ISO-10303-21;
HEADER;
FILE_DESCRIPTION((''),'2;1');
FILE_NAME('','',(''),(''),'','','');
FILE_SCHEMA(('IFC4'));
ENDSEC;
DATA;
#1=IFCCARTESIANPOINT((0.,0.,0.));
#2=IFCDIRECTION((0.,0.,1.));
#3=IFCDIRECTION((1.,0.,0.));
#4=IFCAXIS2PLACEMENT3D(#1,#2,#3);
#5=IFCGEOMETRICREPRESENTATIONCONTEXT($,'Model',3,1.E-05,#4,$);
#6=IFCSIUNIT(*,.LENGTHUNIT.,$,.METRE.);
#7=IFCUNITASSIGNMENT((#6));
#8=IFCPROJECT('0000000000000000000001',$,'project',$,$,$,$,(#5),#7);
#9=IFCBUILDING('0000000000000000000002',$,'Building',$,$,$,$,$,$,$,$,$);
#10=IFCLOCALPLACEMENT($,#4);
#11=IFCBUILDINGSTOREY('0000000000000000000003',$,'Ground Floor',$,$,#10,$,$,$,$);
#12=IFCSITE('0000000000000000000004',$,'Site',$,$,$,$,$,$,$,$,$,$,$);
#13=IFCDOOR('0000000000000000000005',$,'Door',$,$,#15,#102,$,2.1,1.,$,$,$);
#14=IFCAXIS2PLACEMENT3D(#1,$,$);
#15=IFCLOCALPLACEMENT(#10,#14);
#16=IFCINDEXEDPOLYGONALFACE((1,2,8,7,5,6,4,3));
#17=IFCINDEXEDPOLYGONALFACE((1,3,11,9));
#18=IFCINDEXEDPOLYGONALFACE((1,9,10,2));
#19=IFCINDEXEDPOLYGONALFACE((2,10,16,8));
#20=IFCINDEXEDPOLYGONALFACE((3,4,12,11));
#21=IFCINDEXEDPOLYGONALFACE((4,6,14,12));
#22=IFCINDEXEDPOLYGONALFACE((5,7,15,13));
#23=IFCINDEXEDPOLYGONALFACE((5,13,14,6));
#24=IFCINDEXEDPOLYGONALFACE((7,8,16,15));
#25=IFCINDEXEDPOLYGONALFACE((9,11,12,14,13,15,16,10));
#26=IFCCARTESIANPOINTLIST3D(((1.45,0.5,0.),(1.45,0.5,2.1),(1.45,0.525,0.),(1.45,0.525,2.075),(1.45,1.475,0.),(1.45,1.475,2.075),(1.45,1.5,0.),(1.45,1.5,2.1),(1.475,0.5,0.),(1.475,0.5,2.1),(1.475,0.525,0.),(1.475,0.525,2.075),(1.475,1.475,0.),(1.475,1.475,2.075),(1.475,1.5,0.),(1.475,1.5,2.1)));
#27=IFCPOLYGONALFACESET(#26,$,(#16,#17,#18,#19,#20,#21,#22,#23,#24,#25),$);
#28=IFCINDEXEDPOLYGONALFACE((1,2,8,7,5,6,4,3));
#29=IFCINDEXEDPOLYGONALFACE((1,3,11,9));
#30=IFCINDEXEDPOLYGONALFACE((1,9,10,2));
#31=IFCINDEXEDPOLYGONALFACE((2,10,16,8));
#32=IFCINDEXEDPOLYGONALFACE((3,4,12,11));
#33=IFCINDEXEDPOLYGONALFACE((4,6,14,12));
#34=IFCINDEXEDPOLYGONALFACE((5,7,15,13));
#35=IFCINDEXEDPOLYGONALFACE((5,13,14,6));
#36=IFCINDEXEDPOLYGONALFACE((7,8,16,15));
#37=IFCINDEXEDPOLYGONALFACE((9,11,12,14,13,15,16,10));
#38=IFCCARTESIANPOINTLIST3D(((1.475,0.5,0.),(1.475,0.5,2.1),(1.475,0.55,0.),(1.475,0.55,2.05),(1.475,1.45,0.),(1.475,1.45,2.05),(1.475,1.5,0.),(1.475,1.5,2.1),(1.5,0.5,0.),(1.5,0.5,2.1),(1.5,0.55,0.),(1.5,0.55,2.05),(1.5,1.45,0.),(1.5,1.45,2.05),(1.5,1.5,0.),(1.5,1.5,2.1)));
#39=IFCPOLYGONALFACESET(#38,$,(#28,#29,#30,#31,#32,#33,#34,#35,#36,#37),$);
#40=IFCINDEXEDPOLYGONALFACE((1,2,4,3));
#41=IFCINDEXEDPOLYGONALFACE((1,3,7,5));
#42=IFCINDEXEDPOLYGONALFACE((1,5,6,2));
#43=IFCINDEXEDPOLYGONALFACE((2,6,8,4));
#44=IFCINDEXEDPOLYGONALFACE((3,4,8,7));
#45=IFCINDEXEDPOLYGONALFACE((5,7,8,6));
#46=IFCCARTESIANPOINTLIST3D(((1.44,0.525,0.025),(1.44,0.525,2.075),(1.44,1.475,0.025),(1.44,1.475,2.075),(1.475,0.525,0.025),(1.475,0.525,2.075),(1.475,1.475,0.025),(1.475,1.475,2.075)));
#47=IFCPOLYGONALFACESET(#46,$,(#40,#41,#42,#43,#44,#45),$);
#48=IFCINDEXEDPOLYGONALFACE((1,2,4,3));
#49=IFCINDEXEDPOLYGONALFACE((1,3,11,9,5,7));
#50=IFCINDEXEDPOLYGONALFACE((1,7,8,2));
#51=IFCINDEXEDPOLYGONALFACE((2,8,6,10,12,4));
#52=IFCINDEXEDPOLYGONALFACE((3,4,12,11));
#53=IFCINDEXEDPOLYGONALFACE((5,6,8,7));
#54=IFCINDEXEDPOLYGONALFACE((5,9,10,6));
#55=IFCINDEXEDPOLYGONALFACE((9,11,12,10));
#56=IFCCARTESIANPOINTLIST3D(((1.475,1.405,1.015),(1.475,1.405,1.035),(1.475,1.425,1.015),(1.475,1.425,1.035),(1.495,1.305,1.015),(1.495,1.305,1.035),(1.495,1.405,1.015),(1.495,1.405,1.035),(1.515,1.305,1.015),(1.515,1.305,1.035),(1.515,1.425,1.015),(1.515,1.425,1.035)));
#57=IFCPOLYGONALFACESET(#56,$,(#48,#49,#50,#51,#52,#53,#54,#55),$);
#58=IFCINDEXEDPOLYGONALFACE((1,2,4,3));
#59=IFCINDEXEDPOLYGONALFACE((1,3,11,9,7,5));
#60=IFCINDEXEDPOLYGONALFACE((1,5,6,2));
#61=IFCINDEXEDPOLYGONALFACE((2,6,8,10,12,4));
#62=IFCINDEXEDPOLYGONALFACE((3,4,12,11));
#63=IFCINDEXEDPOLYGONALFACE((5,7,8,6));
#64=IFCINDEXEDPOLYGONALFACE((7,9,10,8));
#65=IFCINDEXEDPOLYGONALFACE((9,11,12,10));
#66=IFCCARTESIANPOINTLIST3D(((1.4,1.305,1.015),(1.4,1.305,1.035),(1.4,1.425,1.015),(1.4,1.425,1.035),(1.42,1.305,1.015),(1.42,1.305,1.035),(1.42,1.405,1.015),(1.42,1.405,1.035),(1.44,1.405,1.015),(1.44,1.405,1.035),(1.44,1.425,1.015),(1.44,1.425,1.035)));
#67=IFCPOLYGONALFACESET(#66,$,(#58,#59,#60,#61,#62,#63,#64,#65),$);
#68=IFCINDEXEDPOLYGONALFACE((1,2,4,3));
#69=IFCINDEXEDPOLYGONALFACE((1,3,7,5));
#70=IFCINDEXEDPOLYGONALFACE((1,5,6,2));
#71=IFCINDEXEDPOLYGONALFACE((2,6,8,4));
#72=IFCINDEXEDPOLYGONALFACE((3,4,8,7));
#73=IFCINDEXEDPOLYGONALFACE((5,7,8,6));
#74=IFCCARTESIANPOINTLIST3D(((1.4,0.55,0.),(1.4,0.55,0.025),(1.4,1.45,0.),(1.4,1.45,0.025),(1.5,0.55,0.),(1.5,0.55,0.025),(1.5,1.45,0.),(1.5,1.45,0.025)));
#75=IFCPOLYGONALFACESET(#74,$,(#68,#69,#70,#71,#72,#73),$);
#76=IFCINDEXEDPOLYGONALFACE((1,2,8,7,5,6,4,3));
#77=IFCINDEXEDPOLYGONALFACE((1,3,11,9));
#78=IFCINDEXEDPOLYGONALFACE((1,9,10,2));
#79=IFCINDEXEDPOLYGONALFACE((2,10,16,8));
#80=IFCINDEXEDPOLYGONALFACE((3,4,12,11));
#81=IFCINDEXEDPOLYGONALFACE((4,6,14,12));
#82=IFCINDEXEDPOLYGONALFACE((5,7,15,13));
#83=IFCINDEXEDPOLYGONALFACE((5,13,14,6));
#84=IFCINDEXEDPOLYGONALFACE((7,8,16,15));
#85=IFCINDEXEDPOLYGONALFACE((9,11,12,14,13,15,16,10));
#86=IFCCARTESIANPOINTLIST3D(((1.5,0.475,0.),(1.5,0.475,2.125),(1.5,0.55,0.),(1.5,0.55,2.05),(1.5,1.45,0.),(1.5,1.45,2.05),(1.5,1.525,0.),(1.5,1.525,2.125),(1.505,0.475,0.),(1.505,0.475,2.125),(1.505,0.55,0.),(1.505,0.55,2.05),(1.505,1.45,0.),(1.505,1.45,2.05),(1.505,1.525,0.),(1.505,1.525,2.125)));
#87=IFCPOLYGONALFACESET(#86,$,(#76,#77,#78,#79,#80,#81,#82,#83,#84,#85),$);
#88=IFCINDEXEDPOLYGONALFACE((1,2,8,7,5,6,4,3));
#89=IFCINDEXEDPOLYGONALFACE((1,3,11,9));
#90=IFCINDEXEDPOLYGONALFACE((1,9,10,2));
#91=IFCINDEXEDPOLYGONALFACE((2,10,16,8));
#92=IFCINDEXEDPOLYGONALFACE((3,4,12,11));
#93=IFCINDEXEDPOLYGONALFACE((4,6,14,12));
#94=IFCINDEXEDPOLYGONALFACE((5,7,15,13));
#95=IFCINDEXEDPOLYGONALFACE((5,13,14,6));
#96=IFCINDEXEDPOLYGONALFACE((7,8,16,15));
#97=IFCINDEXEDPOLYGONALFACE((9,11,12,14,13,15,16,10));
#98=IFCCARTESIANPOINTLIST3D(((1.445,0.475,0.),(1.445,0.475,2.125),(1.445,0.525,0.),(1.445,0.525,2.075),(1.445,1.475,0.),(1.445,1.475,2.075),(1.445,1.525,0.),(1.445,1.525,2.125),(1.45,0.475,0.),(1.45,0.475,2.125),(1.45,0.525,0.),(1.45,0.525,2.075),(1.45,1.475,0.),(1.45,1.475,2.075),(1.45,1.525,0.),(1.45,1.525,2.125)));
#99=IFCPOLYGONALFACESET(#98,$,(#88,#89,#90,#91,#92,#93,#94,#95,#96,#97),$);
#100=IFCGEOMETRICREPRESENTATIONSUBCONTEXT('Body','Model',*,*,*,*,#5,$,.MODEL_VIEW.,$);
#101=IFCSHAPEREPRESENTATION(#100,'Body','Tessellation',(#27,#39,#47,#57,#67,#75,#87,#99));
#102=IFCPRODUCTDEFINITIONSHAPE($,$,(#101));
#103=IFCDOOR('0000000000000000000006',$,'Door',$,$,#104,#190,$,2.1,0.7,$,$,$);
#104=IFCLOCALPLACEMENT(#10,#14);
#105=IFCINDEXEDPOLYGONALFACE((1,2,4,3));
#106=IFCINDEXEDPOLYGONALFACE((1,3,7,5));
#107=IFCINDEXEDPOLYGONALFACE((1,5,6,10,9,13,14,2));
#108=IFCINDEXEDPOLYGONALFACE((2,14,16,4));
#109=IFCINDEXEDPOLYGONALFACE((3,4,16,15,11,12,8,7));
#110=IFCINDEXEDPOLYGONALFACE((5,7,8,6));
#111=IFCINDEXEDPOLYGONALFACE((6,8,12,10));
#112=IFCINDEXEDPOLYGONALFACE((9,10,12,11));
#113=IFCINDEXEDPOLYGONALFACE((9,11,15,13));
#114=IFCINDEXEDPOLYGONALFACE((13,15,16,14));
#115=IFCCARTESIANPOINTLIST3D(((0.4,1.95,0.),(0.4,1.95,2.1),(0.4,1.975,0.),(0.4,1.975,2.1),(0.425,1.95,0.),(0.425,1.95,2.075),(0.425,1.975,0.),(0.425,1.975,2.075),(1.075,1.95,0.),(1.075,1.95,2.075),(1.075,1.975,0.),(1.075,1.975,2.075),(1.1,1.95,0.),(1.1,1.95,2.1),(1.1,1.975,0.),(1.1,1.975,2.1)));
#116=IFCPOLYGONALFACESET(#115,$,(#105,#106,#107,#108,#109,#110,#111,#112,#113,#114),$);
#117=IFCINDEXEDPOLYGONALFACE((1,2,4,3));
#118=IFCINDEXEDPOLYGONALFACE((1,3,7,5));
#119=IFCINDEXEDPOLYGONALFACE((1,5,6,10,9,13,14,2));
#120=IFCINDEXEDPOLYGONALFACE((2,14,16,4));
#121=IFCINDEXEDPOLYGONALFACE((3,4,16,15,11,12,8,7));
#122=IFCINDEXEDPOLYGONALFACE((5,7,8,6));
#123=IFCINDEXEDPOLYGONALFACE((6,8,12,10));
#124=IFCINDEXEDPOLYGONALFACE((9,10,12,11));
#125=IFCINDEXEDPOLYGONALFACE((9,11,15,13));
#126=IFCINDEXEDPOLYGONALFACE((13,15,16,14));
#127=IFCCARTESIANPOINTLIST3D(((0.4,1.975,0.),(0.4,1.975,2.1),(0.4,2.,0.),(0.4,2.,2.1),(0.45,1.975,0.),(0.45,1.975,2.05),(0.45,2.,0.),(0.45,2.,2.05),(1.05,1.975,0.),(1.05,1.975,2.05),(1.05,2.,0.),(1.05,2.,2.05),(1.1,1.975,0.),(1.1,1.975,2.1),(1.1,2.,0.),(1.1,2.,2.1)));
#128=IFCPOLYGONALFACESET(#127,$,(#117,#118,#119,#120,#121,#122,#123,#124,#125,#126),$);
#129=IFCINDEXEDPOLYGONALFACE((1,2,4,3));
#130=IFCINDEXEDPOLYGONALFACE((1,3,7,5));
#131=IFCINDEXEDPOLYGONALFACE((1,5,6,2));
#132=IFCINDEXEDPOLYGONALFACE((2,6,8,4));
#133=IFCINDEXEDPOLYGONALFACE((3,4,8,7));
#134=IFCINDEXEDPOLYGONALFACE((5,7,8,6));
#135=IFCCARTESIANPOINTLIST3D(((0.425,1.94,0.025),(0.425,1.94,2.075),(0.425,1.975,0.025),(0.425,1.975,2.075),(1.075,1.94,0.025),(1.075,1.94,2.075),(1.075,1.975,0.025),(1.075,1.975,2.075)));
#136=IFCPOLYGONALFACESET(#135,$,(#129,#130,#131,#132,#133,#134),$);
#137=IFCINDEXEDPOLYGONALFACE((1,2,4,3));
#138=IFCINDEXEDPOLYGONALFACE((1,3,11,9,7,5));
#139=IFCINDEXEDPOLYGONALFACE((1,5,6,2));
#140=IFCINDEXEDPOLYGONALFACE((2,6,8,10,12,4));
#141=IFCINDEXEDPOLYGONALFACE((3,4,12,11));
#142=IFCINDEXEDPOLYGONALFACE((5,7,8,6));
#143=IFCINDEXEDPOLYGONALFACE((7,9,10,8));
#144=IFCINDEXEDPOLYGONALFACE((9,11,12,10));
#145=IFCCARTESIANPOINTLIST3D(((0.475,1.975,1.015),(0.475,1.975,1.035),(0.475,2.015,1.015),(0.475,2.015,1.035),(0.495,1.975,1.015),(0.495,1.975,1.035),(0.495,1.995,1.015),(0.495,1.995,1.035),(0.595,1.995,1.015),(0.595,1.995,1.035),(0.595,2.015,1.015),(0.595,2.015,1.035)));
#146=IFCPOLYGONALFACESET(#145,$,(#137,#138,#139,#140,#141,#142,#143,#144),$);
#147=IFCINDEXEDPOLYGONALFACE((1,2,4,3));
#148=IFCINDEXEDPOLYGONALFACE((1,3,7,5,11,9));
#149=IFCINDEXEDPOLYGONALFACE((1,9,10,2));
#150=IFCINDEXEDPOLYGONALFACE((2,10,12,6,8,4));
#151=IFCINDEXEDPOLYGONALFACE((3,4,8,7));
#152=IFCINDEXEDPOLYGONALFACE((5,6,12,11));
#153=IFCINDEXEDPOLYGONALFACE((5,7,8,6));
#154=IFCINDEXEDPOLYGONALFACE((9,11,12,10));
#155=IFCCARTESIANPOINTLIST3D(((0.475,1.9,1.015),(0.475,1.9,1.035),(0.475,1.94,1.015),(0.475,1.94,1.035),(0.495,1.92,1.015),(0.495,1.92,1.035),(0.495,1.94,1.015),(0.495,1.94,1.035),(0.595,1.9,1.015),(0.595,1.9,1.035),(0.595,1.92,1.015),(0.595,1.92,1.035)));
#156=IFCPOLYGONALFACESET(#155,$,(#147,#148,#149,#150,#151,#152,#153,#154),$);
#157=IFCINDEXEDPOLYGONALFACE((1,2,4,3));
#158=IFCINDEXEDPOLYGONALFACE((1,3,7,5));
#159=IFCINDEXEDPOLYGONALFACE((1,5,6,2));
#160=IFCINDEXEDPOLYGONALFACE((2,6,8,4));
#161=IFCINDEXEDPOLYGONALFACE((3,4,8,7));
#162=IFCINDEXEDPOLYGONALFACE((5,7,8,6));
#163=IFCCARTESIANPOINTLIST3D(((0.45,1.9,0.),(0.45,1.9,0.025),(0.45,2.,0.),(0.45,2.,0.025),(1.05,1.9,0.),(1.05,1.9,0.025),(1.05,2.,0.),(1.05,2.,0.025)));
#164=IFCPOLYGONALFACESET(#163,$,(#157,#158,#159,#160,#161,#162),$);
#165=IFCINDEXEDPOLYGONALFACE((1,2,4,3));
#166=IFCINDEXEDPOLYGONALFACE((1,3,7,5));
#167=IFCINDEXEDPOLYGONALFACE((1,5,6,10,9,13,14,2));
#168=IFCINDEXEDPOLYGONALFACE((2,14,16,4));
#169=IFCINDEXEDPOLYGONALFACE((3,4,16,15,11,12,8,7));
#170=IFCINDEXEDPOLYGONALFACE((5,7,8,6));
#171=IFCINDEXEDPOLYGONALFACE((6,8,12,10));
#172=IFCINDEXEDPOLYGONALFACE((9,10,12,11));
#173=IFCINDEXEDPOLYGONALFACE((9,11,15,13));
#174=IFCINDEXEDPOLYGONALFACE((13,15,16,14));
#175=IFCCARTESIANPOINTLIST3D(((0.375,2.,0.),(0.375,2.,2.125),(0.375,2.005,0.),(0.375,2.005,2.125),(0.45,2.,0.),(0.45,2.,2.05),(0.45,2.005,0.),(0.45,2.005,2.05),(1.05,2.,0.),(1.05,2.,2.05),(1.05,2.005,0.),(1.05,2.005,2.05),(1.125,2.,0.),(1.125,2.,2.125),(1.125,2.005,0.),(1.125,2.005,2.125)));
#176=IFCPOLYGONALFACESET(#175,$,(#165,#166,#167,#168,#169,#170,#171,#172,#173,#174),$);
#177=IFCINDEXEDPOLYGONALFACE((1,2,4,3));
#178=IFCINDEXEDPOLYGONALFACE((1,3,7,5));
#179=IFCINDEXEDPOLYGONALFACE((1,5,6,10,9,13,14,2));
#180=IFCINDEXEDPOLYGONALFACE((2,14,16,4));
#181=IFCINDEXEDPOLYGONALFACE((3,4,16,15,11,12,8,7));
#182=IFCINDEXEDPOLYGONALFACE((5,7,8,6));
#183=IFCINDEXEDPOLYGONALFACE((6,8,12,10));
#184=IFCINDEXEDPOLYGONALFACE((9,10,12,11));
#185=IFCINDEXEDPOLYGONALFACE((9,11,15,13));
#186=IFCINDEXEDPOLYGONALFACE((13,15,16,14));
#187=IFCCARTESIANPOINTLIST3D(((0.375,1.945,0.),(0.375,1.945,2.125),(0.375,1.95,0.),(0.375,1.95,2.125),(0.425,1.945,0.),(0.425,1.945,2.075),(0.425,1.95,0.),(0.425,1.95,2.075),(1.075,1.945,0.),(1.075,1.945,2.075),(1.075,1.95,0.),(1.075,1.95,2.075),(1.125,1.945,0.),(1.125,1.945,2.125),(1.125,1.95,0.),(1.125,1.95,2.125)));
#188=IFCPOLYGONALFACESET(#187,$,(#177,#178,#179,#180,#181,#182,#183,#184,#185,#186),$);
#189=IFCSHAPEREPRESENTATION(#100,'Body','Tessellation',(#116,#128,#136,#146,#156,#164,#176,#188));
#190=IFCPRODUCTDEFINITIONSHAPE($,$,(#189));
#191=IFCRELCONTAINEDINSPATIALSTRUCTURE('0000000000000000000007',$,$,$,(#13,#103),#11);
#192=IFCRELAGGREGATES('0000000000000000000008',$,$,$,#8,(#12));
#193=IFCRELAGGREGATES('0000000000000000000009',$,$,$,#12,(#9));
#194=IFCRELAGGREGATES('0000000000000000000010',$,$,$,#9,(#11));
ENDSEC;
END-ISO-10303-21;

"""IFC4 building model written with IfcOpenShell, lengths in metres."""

from ifc_helpers import new_model, si_unit, frame, origin_with_axes, place, context, subcontext, project, spatial, line, indexed_curve, outline, extrude, element, save


model = new_model("IFC4")

# Units and contexts
model_context = context("Model", 3, precision=1e-05, world=origin_with_axes())
body_context = subcontext(model_context, "Body", "Model", "MODEL_VIEW")
ifc_project = project(units=[si_unit("LENGTHUNIT", "METRE")], contexts=[model_context])

# Site, building, storey
site = spatial("IfcSite", under=ifc_project, Name="Site")
building = spatial("IfcBuilding", under=site, Name="Building")
storey_placement = place(None, origin_with_axes())
storey = spatial("IfcBuildingStorey", under=building, at=storey_placement, Name="Ground Floor")

# Doors
door_1_placement = place(storey_placement, frame((1.5, 0.5, 0.0), z_axis=(0.0, 0.0, 1.0), x_axis=(0.0, 1.0, 0.0)))
element("IfcDoor", 1, at=door_1_placement, inside=storey, Name="Door", OverallHeight=2.1, OverallWidth=1.0, context=body_context, shape_type="SweptSolid", body=[
    extrude(outline(indexed_curve([(0.0, 0.0), (0.0, 2.1), (1.0, 2.1), (1.0, 0.0), (0.975, 0.0), (0.975, 2.075), (0.025, 2.075), (0.025, 0.0)], segments=[line(1, 2, 3, 4, 5, 6, 7, 8, 1)])), frame((0.0, 0.025, 0.0), z_axis=(0.0, -1.0, 0.0), x_axis=(1.0, 0.0, 0.0)), (0.0, 0.0, -1.0), 0.025),
    extrude(outline(indexed_curve([(0.0, 0.0), (0.0, 2.1), (1.0, 2.1), (1.0, 0.0), (0.95, 0.0), (0.95, 2.05), (0.05, 2.05), (0.05, 0.0)], segments=[line(1, 2, 3, 4, 5, 6, 7, 8, 1)])), frame((0.0, 0.0, 0.0), z_axis=(0.0, -1.0, 0.0), x_axis=(1.0, 0.0, 0.0)), (0.0, 0.0, -1.0), 0.025),
    extrude(outline(indexed_curve([(0.0, 0.0), (0.95, 0.0), (0.95, 0.035), (0.0, 0.035)], segments=[line(1, 2, 3, 4, 1)])), frame((0.025, 0.025, 0.025), z_axis=(0.0, 0.0, 1.0), x_axis=(1.0, 0.0, 0.0)), (0.0, 0.0, 1.0), 2.05),
    extrude(outline(indexed_curve([(0.0, 0.0), (0.0, -0.04), (-0.12, -0.04), (-0.12, -0.02), (-0.02, -0.02), (-0.02, 0.0)], segments=[line(1, 2, 3, 4, 5, 6, 1)])), frame((0.925, 0.025, 1.015), z_axis=(0.0, 0.0, 1.0), x_axis=(1.0, 0.0, 0.0)), (0.0, 0.0, 1.0), 0.02),
    extrude(outline(indexed_curve([(0.0, 0.0), (0.0, 0.04), (-0.12, 0.04), (-0.12, 0.02), (-0.02, 0.02), (-0.02, 0.0)], segments=[line(1, 2, 3, 4, 5, 6, 1)])), frame((0.925, 0.06, 1.015), z_axis=(0.0, 0.0, 1.0), x_axis=(1.0, 0.0, 0.0)), (0.0, 0.0, 1.0), 0.02),
    extrude(outline(indexed_curve([(0.0, 0.0), (0.9, 0.0), (0.9, 0.1), (0.0, 0.1)], segments=[line(1, 2, 3, 4, 1)])), frame((0.05, 0.0, 0.0), z_axis=(0.0, 0.0, 1.0), x_axis=(1.0, 0.0, 0.0)), (0.0, 0.0, 1.0), 0.025),
    extrude(outline(indexed_curve([(0.0, 0.0), (0.0, 2.125), (1.05, 2.125), (1.05, 0.0), (0.975, 0.0), (0.975, 2.05), (0.075, 2.05), (0.075, 0.0)], segments=[line(1, 2, 3, 4, 5, 6, 7, 8, 1)])), frame((-0.025, -0.005, 0.0), z_axis=(0.0, -1.0, 0.0), x_axis=(1.0, 0.0, 0.0)), (0.0, 0.0, -1.0), 0.005),
    extrude(outline(indexed_curve([(0.0, 0.0), (0.0, 2.125), (1.05, 2.125), (1.05, 0.0), (1.0, 0.0), (1.0, 2.075), (0.05, 2.075), (0.05, 0.0)], segments=[line(1, 2, 3, 4, 5, 6, 7, 8, 1)])), frame((-0.025, 0.05, 0.0), z_axis=(0.0, -1.0, 0.0), x_axis=(1.0, 0.0, 0.0)), (0.0, 0.0, -1.0), 0.005),
])
door_2_placement = place(storey_placement, frame((1.1, 2.0, 0.0), z_axis=(0.0, 0.0, 1.0), x_axis=(-1.0, 0.0, 0.0)))
element("IfcDoor", 2, at=door_2_placement, inside=storey, Name="Door", OverallHeight=2.1, OverallWidth=0.7, context=body_context, shape_type="SweptSolid", body=[
    extrude(outline(indexed_curve([(0.0, 0.0), (0.0, 2.1), (0.7, 2.1), (0.7, 0.0), (0.675, 0.0), (0.675, 2.075), (0.025, 2.075), (0.025, 0.0)], segments=[line(1, 2, 3, 4, 5, 6, 7, 8, 1)])), frame((0.0, 0.025, 0.0), z_axis=(0.0, -1.0, 0.0), x_axis=(1.0, 0.0, 0.0)), (0.0, 0.0, -1.0), 0.025),
    extrude(outline(indexed_curve([(0.0, 0.0), (0.0, 2.1), (0.7, 2.1), (0.7, 0.0), (0.65, 0.0), (0.65, 2.05), (0.05, 2.05), (0.05, 0.0)], segments=[line(1, 2, 3, 4, 5, 6, 7, 8, 1)])), frame((0.0, 0.0, 0.0), z_axis=(0.0, -1.0, 0.0), x_axis=(1.0, 0.0, 0.0)), (0.0, 0.0, -1.0), 0.025),
    extrude(outline(indexed_curve([(0.0, 0.0), (0.65, 0.0), (0.65, 0.035), (0.0, 0.035)], segments=[line(1, 2, 3, 4, 1)])), frame((0.025, 0.025, 0.025), z_axis=(0.0, 0.0, 1.0), x_axis=(1.0, 0.0, 0.0)), (0.0, 0.0, 1.0), 2.05),
    extrude(outline(indexed_curve([(0.0, 0.0), (0.0, -0.04), (-0.12, -0.04), (-0.12, -0.02), (-0.02, -0.02), (-0.02, 0.0)], segments=[line(1, 2, 3, 4, 5, 6, 1)])), frame((0.625, 0.025, 1.015), z_axis=(0.0, 0.0, 1.0), x_axis=(1.0, 0.0, 0.0)), (0.0, 0.0, 1.0), 0.02),
    extrude(outline(indexed_curve([(0.0, 0.0), (0.0, 0.04), (-0.12, 0.04), (-0.12, 0.02), (-0.02, 0.02), (-0.02, 0.0)], segments=[line(1, 2, 3, 4, 5, 6, 1)])), frame((0.625, 0.06, 1.015), z_axis=(0.0, 0.0, 1.0), x_axis=(1.0, 0.0, 0.0)), (0.0, 0.0, 1.0), 0.02),
    extrude(outline(indexed_curve([(0.0, 0.0), (0.6, 0.0), (0.6, 0.1), (0.0, 0.1)], segments=[line(1, 2, 3, 4, 1)])), frame((0.05, 0.0, 0.0), z_axis=(0.0, 0.0, 1.0), x_axis=(1.0, 0.0, 0.0)), (0.0, 0.0, 1.0), 0.025),
    extrude(outline(indexed_curve([(0.0, 0.0), (0.0, 2.125), (0.75, 2.125), (0.75, 0.0), (0.675, 0.0), (0.675, 2.05), (0.075, 2.05), (0.075, 0.0)], segments=[line(1, 2, 3, 4, 5, 6, 7, 8, 1)])), frame((-0.025, -0.005, 0.0), z_axis=(0.0, -1.0, 0.0), x_axis=(1.0, 0.0, 0.0)), (0.0, 0.0, -1.0), 0.005),
    extrude(outline(indexed_curve([(0.0, 0.0), (0.0, 2.125), (0.75, 2.125), (0.75, 0.0), (0.7, 0.0), (0.7, 2.075), (0.05, 2.075), (0.05, 0.0)], segments=[line(1, 2, 3, 4, 5, 6, 7, 8, 1)])), frame((-0.025, 0.05, 0.0), z_axis=(0.0, -1.0, 0.0), x_axis=(1.0, 0.0, 0.0)), (0.0, 0.0, -1.0), 0.005),
])

save(model, "model.ifc")
